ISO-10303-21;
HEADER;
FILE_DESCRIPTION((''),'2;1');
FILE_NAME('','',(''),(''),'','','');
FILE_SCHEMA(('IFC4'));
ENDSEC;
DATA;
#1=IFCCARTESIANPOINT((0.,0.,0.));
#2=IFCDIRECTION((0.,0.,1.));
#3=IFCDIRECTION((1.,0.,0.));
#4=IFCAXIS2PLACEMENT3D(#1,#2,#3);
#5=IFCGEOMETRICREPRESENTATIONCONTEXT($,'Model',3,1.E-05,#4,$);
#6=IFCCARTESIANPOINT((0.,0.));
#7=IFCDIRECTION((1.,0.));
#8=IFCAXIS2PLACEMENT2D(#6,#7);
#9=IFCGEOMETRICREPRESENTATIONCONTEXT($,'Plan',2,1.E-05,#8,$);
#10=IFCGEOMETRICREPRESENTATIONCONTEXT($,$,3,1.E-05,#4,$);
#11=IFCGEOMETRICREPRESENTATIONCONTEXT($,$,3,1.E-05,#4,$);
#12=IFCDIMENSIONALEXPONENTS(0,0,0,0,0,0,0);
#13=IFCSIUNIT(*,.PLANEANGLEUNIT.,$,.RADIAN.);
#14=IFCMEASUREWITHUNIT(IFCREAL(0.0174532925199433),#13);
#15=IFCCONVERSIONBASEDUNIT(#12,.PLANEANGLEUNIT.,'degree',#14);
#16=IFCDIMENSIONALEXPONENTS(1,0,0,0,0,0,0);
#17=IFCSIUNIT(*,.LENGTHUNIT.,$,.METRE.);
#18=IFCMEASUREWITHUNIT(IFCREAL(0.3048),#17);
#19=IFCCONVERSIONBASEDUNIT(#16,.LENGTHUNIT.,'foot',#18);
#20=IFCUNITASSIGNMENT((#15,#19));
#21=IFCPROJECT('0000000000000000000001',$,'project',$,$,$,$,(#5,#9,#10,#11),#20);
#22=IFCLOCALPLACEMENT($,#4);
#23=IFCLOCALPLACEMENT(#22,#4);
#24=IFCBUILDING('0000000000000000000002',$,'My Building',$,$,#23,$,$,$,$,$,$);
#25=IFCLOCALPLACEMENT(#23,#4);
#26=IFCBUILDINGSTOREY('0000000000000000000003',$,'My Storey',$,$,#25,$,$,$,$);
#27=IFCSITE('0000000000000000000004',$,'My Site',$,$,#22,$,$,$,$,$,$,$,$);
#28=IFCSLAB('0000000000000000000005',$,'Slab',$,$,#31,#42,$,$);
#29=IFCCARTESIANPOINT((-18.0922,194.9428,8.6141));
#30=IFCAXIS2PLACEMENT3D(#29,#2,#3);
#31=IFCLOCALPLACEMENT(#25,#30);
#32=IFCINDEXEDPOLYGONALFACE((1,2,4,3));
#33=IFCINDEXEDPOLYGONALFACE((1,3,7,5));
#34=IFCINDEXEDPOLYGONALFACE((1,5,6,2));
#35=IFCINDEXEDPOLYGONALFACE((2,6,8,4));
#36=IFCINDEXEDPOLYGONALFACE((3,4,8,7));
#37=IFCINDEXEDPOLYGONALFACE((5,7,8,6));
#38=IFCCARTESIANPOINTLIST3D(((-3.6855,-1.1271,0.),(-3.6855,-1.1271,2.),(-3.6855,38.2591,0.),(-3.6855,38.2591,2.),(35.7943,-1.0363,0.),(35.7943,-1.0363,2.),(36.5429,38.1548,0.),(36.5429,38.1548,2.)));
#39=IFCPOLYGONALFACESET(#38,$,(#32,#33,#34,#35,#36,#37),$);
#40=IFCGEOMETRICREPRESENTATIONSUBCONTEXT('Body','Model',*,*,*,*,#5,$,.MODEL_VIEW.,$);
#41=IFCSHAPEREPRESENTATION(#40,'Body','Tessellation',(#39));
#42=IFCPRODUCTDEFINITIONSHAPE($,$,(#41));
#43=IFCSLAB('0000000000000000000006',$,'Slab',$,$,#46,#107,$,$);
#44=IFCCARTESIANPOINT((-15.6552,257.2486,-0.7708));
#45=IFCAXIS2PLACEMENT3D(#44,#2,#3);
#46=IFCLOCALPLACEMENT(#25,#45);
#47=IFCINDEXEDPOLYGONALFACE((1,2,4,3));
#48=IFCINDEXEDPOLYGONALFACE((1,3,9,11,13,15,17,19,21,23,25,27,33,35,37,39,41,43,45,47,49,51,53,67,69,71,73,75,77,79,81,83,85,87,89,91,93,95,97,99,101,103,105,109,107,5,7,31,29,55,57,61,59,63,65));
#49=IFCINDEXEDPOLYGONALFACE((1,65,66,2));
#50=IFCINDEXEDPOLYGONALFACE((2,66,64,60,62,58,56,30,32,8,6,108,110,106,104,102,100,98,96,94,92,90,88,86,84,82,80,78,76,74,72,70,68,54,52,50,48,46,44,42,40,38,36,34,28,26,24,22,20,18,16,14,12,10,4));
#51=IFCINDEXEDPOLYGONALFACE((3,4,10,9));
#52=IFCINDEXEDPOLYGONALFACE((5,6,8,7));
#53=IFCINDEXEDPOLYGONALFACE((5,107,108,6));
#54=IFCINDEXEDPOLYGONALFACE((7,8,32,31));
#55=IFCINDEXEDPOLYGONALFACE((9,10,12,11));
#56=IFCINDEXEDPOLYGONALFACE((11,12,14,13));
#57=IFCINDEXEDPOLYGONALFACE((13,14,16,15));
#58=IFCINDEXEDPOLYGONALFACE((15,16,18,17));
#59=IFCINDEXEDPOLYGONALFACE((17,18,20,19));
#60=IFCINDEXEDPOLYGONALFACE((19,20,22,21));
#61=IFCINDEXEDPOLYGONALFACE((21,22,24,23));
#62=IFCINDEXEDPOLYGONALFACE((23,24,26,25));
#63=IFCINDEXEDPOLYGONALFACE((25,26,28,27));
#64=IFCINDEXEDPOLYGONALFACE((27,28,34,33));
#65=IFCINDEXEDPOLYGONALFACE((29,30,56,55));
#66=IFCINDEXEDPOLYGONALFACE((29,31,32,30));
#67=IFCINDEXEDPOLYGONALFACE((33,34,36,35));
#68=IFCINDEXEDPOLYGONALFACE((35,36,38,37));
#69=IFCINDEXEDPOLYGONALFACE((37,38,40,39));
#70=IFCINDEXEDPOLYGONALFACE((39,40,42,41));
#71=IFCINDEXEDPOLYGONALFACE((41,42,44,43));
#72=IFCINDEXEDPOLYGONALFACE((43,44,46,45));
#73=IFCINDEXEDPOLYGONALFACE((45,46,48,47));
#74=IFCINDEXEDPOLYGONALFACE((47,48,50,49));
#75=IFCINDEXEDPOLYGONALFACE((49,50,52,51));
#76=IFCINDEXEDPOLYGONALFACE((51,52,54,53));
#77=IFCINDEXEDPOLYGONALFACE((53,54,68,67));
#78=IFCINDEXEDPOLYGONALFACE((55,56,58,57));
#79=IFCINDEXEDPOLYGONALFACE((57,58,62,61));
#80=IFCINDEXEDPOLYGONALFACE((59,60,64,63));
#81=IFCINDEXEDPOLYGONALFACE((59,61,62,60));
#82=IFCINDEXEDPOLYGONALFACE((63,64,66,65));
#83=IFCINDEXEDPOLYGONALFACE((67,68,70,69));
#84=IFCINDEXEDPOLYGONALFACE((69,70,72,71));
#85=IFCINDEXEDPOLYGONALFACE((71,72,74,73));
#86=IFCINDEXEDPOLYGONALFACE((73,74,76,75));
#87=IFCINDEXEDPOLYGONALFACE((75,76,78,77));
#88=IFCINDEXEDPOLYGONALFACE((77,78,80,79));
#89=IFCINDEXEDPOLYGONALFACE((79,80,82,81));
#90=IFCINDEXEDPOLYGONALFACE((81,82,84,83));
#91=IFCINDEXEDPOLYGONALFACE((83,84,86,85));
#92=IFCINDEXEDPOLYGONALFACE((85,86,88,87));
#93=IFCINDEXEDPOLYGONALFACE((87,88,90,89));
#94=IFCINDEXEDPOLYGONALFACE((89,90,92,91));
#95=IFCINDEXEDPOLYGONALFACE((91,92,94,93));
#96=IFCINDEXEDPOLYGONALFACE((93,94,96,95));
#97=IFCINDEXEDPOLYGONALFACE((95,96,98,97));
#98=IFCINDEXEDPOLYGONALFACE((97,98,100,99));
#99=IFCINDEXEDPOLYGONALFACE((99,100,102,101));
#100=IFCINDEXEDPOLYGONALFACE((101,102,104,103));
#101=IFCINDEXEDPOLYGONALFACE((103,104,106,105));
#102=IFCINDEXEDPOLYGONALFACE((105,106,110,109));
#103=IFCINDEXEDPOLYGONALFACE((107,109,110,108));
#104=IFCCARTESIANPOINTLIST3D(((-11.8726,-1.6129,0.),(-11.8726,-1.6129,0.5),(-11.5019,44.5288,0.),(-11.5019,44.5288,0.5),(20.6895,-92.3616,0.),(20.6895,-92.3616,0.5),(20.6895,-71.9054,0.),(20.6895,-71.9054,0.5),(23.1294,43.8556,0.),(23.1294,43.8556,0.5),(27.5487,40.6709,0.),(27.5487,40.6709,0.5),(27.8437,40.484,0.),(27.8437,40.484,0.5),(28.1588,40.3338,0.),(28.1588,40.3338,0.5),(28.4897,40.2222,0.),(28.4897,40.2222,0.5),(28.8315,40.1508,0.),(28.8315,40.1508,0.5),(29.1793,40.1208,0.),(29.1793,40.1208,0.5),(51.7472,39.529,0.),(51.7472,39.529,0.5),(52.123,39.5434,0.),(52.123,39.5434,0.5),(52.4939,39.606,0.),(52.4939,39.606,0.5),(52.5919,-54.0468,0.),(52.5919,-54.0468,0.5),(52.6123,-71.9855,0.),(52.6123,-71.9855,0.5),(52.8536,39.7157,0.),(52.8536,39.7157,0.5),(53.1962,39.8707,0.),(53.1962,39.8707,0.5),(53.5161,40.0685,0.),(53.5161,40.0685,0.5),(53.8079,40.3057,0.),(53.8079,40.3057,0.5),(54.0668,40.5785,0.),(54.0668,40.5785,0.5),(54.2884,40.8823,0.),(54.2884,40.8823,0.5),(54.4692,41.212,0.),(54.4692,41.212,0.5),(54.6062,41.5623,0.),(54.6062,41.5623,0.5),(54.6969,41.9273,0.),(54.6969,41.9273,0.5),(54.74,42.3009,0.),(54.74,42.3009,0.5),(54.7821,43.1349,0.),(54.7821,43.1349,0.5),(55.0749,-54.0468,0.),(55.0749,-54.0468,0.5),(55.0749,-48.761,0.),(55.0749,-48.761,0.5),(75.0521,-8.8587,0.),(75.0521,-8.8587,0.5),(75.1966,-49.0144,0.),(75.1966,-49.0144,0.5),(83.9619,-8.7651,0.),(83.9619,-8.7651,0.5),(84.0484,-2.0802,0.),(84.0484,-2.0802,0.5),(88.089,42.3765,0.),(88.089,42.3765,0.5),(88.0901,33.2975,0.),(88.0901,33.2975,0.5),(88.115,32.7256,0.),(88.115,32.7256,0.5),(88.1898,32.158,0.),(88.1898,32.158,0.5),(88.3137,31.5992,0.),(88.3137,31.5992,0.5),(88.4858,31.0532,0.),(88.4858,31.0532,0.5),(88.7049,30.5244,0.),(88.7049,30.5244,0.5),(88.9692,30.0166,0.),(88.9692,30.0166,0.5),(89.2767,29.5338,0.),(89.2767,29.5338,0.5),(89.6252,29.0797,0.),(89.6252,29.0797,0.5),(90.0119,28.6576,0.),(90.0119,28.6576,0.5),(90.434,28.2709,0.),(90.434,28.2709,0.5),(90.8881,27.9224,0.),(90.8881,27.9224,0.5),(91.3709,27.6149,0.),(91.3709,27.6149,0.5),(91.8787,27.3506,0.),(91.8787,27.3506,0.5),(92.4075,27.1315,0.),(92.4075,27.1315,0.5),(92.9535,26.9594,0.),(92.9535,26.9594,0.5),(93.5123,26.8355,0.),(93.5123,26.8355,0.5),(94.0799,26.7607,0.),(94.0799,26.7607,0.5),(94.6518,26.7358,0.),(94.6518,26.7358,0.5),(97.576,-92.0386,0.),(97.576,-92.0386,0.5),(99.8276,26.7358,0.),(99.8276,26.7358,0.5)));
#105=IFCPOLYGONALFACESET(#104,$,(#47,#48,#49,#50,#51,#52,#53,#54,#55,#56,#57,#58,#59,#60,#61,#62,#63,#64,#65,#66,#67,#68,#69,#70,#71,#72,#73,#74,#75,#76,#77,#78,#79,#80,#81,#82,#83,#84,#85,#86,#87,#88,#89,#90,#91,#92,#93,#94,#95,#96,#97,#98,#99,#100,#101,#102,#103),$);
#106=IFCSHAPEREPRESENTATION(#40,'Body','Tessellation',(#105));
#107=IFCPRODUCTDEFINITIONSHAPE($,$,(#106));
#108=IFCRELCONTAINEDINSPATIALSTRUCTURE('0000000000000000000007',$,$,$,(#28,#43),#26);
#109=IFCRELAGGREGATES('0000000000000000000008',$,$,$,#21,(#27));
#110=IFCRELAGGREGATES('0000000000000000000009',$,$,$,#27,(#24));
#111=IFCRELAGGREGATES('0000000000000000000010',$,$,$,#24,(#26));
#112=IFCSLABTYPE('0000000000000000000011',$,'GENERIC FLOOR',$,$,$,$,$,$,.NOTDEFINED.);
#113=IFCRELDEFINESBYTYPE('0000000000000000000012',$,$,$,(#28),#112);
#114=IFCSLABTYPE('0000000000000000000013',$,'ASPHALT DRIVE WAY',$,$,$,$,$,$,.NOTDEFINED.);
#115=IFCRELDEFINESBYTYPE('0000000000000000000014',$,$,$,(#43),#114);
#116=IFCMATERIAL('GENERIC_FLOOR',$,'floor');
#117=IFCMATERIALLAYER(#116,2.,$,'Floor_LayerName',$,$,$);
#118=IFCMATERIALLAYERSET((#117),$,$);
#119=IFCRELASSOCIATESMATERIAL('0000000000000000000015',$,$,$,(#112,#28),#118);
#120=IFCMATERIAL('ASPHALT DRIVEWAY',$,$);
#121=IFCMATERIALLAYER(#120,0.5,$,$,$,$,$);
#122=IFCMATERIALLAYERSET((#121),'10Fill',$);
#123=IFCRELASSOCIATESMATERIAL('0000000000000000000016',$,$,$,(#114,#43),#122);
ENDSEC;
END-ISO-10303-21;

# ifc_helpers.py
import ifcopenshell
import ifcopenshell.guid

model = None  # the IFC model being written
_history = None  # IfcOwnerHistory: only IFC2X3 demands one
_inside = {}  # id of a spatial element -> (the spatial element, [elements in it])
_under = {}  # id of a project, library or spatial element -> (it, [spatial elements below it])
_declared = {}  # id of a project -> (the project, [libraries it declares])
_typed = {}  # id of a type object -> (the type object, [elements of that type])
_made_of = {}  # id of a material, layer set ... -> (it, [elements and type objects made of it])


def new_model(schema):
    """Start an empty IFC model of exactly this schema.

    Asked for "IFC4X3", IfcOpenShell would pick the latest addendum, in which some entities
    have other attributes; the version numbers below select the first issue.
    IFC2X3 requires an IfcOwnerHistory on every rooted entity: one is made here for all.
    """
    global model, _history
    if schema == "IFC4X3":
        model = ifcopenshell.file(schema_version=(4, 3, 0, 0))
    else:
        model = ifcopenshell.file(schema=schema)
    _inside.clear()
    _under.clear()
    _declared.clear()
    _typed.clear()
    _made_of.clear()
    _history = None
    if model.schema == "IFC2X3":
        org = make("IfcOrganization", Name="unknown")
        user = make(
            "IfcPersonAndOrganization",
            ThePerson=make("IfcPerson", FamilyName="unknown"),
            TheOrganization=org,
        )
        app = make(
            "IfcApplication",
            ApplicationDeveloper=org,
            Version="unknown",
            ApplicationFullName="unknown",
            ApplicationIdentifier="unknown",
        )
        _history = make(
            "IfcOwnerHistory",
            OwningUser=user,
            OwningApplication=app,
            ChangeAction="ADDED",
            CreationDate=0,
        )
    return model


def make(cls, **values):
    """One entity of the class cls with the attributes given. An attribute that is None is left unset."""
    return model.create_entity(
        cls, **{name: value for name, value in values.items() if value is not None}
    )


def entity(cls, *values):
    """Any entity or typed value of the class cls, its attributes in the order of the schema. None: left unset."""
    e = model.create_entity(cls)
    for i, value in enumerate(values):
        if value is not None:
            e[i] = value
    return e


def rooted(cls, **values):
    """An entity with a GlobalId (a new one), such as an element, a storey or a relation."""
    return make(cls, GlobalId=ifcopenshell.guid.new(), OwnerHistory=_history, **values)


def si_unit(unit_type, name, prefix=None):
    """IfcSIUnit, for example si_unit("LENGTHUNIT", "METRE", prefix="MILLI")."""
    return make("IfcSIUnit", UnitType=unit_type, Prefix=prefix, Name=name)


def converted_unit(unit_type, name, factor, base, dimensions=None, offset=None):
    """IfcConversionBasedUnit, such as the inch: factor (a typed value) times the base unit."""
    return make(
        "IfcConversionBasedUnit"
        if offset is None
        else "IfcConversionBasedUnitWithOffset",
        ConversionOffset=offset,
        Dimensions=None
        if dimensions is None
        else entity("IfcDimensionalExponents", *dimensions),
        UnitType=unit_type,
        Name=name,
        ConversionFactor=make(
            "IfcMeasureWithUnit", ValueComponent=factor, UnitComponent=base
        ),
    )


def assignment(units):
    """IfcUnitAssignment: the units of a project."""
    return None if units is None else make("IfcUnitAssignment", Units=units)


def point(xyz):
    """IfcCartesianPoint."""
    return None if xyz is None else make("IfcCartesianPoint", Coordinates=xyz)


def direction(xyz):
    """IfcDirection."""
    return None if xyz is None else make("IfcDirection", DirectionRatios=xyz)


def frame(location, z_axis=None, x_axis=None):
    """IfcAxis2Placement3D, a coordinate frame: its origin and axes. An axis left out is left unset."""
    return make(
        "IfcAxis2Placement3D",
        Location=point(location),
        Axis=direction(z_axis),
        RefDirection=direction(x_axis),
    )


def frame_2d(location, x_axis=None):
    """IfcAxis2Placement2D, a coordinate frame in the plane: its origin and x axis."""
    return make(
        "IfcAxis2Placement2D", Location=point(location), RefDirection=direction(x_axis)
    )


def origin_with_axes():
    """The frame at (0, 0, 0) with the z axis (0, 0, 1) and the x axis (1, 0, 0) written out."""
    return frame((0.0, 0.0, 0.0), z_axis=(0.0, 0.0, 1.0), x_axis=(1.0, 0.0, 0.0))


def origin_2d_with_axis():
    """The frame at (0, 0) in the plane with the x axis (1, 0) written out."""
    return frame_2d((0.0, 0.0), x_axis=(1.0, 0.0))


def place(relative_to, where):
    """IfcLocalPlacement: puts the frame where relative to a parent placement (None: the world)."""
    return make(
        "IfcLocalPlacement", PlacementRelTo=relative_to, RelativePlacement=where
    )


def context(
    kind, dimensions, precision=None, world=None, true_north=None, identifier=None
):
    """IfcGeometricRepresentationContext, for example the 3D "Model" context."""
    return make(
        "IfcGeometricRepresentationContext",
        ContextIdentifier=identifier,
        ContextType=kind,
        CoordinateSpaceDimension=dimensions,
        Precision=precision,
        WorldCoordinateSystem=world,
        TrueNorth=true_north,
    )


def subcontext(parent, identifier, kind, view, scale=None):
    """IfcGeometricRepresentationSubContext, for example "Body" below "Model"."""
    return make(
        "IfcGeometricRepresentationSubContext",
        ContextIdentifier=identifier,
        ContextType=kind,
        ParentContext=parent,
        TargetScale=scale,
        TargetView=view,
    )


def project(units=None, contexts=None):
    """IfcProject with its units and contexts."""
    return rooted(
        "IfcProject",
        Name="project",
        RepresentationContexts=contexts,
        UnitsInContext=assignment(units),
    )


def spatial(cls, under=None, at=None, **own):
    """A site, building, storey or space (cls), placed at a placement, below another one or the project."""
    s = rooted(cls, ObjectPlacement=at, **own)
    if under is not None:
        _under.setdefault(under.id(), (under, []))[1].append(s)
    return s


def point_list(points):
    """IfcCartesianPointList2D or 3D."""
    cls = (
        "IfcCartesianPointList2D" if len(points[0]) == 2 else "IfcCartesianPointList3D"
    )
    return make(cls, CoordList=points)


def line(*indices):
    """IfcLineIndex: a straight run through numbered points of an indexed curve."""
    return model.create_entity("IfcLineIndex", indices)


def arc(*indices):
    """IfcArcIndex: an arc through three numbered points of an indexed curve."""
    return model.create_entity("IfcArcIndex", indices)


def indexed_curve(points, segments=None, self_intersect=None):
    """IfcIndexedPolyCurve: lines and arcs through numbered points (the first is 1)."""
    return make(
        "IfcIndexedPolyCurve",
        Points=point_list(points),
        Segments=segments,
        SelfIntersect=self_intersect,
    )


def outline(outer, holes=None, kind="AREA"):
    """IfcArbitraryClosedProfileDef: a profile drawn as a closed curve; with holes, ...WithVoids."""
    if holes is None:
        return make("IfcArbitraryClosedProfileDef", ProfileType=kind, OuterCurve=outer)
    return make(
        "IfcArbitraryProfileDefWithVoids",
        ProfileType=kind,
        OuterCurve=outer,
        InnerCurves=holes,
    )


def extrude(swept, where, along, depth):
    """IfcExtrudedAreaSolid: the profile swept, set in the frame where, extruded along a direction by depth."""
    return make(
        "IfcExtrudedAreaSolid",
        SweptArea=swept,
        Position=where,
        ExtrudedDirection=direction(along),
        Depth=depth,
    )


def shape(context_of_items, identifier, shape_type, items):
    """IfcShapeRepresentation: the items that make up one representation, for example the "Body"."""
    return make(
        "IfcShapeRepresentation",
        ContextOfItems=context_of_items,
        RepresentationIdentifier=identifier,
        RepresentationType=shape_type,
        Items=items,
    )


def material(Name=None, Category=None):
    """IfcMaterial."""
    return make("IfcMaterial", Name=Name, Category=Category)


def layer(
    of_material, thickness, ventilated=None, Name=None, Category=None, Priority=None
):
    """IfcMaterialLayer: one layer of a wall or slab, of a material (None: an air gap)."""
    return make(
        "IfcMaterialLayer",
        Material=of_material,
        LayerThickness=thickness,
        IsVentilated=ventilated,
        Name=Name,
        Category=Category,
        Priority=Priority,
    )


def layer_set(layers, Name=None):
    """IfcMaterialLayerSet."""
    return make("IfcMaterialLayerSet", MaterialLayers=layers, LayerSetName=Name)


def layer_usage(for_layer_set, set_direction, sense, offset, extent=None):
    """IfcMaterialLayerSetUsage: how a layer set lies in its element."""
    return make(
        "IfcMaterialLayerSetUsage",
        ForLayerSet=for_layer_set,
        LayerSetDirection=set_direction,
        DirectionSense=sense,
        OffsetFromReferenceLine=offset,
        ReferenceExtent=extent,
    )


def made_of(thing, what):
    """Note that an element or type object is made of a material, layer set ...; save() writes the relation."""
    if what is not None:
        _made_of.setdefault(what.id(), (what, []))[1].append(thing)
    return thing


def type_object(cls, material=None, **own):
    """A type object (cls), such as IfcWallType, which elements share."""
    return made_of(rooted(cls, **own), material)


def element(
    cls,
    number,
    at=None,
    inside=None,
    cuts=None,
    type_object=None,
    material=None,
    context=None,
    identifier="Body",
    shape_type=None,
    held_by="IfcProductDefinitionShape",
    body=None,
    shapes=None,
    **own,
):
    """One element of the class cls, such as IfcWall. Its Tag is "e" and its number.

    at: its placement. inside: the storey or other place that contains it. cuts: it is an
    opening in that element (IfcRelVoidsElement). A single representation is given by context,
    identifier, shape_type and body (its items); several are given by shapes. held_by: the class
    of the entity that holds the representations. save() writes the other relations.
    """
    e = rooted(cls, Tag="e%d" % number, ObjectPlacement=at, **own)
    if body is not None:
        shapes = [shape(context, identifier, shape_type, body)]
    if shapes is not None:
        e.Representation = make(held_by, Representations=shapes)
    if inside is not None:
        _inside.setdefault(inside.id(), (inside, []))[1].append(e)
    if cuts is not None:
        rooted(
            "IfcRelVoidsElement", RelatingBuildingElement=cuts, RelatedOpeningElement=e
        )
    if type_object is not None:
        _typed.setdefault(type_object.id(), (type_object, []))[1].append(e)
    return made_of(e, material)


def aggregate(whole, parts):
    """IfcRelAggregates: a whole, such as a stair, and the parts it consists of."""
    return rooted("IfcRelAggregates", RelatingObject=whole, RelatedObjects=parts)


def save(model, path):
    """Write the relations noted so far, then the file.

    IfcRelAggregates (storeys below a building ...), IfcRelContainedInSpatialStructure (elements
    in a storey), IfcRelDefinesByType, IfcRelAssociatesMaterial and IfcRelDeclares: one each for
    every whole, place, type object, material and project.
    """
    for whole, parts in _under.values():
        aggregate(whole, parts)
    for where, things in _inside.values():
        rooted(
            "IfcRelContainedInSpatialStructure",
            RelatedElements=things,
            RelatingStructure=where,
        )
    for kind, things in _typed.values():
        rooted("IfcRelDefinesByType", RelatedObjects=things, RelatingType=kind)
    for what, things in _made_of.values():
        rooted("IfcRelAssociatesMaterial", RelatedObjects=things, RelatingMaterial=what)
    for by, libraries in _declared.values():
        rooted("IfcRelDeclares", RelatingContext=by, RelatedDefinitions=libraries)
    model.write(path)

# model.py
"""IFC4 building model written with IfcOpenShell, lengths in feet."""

from ifc_helpers import new_model, entity, si_unit, converted_unit, frame, origin_with_axes, origin_2d_with_axis, place, context, subcontext, project, spatial, line, arc, indexed_curve, outline, extrude, material, layer, layer_set, layer_usage, type_object, element, save


model = new_model("IFC4")

# Units and contexts
model_context = context("Model", 3, precision=1e-05, world=origin_with_axes())
plan_context = context("Plan", 2, precision=1e-05, world=origin_2d_with_axis())
context_of_model_1 = context(None, 3, precision=1e-05, world=origin_with_axes())
context_of_model_2 = context(None, 3, precision=1e-05, world=origin_with_axes())
body_context = subcontext(model_context, "Body", "Model", "MODEL_VIEW")
ifc_project = project(units=[converted_unit("PLANEANGLEUNIT", "degree", entity("IfcReal", 0.0174532925199433), si_unit("PLANEANGLEUNIT", "RADIAN"), dimensions=[0, 0, 0, 0, 0, 0, 0]), converted_unit("LENGTHUNIT", "foot", entity("IfcReal", 0.3048), si_unit("LENGTHUNIT", "METRE"), dimensions=[1, 0, 0, 0, 0, 0, 0])], contexts=[model_context, plan_context, context_of_model_1, context_of_model_2])

# Site, building, storey
site_placement = place(None, origin_with_axes())
site = spatial("IfcSite", under=ifc_project, at=site_placement, Name="My Site")
building_placement = place(site_placement, origin_with_axes())
building = spatial("IfcBuilding", under=site, at=building_placement, Name="My Building")
storey_placement = place(building_placement, origin_with_axes())
storey = spatial("IfcBuildingStorey", under=building, at=storey_placement, Name="My Storey")

# Slabs
ifc_material_1 = material(Name="GENERIC_FLOOR", Category="floor")
ifc_layer_1 = layer(ifc_material_1, 2.0, Name="Floor_LayerName")
ifc_layer_set_1 = layer_set([ifc_layer_1])
ifc_layer_usage_1 = layer_usage(ifc_layer_set_1, "AXIS3", "POSITIVE", 0.0)
slab_type_1 = type_object("IfcSlabType", Name="GENERIC FLOOR", PredefinedType="NOTDEFINED", material=ifc_layer_set_1)
slab_1_placement = place(storey_placement, frame((-18.0922, 194.9428, 8.6141), z_axis=(0.0, 0.0, 1.0), x_axis=(1.0, 0.0, 0.0)))
element("IfcSlab", 1, at=slab_1_placement, inside=storey, type_object=slab_type_1, material=ifc_layer_usage_1, Name="Slab", context=body_context, shape_type="SweptSolid", body=[
    extrude(outline(indexed_curve([(36.5429, 38.1548), (-3.6855, 38.2591), (-3.6855, -1.1271), (35.7943, -1.0363)], segments=[line(4, 1), line(1, 2), line(2, 3), line(3, 4)], self_intersect=False)), None, (0.0, 0.0, 1.0), 2.0),
])
ifc_material_2 = material(Name="ASPHALT DRIVEWAY")
ifc_layer_2 = layer(ifc_material_2, 0.5)
ifc_layer_set_2 = layer_set([ifc_layer_2], Name="10Fill")
ifc_layer_usage_2 = layer_usage(ifc_layer_set_2, "AXIS3", "POSITIVE", 0.0)
slab_type_2 = type_object("IfcSlabType", Name="ASPHALT DRIVE WAY", PredefinedType="NOTDEFINED", material=ifc_layer_set_2)
slab_2_placement = place(storey_placement, frame((-15.6552, 257.2486, -0.7708), z_axis=(0.0, 0.0, 1.0), x_axis=(1.0, 0.0, 0.0)))
element("IfcSlab", 2, at=slab_2_placement, inside=storey, type_object=slab_type_2, material=ifc_layer_usage_2, Name="Slab", context=body_context, shape_type="SweptSolid", body=[
    extrude(outline(indexed_curve([(29.1793, 40.1208), (28.3226, 40.273), (27.5487, 40.6709), (23.1294, 43.8556), (-11.5019, 44.5288), (-11.8726, -1.6129), (84.0484, -2.0802), (83.9619, -8.7651), (75.0521, -8.8587), (75.1966, -49.0144), (55.0749, -48.761), (55.0749, -54.0468), (52.5919, -54.0468), (52.6123, -71.9855), (20.6895, -71.9054), (20.6895, -92.3616), (97.576, -92.0386), (99.8276, 26.7358), (94.6518, 26.7358), (90.0119, 28.6576), (88.0901, 33.2975), (88.089, 42.3765), (54.7821, 43.1349), (54.74, 42.3009), (53.8079, 40.3057), (51.7472, 39.529)], segments=[line(13, 12), line(12, 11), line(11, 10), line(10, 9), line(9, 8), line(8, 7), line(7, 6), line(6, 5), line(5, 4), line(4, 3), arc(3, 2, 1), line(1, 26), arc(26, 25, 24), line(24, 23), line(23, 22), line(22, 21), arc(21, 20, 19), line(19, 18), line(18, 17), line(17, 16), line(16, 15), line(15, 14), line(14, 13)], self_intersect=False)), None, (0.0, 0.0, 1.0), 0.5),
])

save(model, "model.ifc")
